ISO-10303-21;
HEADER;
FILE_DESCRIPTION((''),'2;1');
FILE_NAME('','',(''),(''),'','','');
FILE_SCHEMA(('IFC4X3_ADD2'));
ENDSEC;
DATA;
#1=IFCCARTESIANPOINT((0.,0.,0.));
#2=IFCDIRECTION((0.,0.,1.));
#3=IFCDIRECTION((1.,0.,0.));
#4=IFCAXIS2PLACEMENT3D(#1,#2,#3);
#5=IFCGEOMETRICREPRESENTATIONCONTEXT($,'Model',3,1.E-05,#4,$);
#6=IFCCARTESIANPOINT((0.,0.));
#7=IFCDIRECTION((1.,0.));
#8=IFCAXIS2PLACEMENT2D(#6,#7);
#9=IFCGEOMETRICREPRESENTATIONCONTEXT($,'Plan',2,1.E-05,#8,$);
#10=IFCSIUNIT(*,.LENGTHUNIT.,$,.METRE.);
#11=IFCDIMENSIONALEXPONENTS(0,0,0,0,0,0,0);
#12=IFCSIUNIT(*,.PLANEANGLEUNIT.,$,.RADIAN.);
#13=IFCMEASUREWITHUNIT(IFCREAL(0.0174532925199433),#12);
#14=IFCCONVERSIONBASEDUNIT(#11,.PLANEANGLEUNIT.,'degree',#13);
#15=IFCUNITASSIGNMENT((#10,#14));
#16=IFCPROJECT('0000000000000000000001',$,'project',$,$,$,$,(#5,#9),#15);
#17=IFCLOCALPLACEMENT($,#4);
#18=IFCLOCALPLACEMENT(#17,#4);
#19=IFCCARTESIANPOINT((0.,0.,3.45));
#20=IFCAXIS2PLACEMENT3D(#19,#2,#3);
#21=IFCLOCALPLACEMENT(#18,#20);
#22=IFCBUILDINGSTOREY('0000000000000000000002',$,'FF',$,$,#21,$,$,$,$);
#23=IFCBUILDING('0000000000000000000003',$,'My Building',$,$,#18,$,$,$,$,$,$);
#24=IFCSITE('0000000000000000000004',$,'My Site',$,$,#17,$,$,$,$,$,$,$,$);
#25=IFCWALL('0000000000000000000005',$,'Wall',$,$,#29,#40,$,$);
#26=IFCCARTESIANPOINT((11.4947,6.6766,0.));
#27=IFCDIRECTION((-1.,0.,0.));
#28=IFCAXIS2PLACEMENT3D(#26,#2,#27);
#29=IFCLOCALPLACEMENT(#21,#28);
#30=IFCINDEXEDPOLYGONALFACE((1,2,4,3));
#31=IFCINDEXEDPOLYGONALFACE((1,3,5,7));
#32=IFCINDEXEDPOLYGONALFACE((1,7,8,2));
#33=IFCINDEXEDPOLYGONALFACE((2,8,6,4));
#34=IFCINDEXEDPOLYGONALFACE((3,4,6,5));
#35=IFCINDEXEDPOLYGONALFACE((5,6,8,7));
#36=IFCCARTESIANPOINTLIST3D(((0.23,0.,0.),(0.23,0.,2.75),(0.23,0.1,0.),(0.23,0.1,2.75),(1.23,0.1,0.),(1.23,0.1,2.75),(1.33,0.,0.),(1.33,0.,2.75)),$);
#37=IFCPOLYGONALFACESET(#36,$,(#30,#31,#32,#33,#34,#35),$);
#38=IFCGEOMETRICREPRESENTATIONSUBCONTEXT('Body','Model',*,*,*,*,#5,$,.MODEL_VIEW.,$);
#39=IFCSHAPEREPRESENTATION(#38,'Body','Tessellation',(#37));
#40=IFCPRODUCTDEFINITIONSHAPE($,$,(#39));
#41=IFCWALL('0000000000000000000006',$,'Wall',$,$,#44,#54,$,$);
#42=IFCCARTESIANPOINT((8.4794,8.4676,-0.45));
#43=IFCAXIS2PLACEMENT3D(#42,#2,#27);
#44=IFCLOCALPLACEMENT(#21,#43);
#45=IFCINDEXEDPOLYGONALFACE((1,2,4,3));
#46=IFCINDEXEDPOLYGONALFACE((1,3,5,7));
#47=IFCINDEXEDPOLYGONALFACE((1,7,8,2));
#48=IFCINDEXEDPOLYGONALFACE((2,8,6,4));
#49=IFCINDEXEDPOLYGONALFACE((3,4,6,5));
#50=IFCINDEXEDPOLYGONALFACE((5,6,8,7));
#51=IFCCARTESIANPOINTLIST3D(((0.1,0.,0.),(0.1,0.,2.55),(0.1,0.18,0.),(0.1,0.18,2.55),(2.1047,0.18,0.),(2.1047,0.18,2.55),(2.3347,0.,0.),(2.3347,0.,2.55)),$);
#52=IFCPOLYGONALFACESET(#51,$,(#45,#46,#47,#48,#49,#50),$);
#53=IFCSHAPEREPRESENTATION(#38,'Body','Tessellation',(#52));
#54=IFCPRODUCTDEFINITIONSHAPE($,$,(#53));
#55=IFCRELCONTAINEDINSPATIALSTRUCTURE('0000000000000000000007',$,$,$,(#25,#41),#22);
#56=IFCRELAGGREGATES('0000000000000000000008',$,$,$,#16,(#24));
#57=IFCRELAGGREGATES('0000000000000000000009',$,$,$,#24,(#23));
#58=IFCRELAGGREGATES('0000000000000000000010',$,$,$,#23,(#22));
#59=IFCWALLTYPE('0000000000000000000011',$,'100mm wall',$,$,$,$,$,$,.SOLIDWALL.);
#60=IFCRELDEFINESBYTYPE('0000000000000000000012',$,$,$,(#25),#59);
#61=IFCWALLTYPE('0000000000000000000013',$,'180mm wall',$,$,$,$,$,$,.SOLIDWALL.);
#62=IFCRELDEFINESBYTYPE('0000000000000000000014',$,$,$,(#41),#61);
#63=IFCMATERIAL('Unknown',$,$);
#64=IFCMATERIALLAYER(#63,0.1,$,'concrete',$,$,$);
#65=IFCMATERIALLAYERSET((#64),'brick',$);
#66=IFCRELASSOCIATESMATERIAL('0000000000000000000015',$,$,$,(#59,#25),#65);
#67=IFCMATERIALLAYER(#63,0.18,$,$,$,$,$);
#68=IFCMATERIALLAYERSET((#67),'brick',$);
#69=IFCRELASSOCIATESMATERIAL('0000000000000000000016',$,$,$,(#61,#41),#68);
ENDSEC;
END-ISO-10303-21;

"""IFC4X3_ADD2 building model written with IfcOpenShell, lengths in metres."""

from ifc_helpers import new_model, entity, si_unit, converted_unit, frame, origin_with_axes, origin_2d_with_axis, place, context, subcontext, project, spatial, line, indexed_curve, outline, extrude, material, layer, layer_set, layer_usage, type_object, element, save


model = new_model("IFC4X3_ADD2")

# Units and contexts
model_context = context("Model", 3, precision=1e-05, world=origin_with_axes())
plan_context = context("Plan", 2, precision=1e-05, world=origin_2d_with_axis())
body_context_1 = subcontext(model_context, "Body", "Model", "MODEL_VIEW")
ifc_project = project(units=[si_unit("LENGTHUNIT", "METRE"), converted_unit("PLANEANGLEUNIT", "degree", entity("IfcReal", 0.0174532925199433), si_unit("PLANEANGLEUNIT", "RADIAN"), dimensions=[0, 0, 0, 0, 0, 0, 0])], contexts=[model_context, plan_context])

# Site, building, storey
site_placement = place(None, origin_with_axes())
site = spatial("IfcSite", under=ifc_project, at=site_placement, Name="My Site")
building_placement = place(site_placement, origin_with_axes())
building = spatial("IfcBuilding", under=site, at=building_placement, Name="My Building")
storey_placement = place(building_placement, frame((0.0, 0.0, 3.45), z_axis=(0.0, 0.0, 1.0), x_axis=(1.0, 0.0, 0.0)))
storey = spatial("IfcBuildingStorey", under=building, at=storey_placement, Name="FF")

# Shared definitions
ifc_material = material(Name="Unknown")

# Shared definitions
ifc_layer_1 = layer(ifc_material, 0.1, Name="concrete")
ifc_layer_set_1 = layer_set([ifc_layer_1], Name="brick")
wall_type_1 = type_object("IfcWallType", Name="100mm wall", PredefinedType="SOLIDWALL", material=ifc_layer_set_1)

# Walls
ifc_layer_usage_1 = layer_usage(ifc_layer_set_1, "AXIS2", "POSITIVE", 0.0)
wall_1_placement = place(storey_placement, frame((11.4947, 6.6766, 0.0), z_axis=(0.0, 0.0, 1.0), x_axis=(-1.0, 0.0, 0.0)))
element("IfcWall", 1, at=wall_1_placement, inside=storey, type_object=wall_type_1, material=ifc_layer_usage_1, Name="Wall", context=body_context_1, shape_type="SweptSolid", body=[
    extrude(outline(indexed_curve([(0.23, 0.0), (0.23, 0.1), (1.23, 0.1), (1.33, 0.0)], segments=[line(1, 2, 3, 4, 1)])), origin_with_axes(), (0.0, 0.0, 1.0), 2.75),
])
ifc_layer_2 = layer(ifc_material, 0.18)
ifc_layer_set_2 = layer_set([ifc_layer_2], Name="brick")
ifc_layer_usage_2 = layer_usage(ifc_layer_set_2, "AXIS2", "POSITIVE", 0.0)
wall_type_2 = type_object("IfcWallType", Name="180mm wall", PredefinedType="SOLIDWALL", material=ifc_layer_set_2)
wall_2_placement = place(storey_placement, frame((8.4794, 8.4676, -0.45), z_axis=(0.0, 0.0, 1.0), x_axis=(-1.0, 0.0, 0.0)))
element("IfcWall", 2, at=wall_2_placement, inside=storey, type_object=wall_type_2, material=ifc_layer_usage_2, Name="Wall", context=body_context_1, shape_type="SweptSolid", body=[
    extrude(outline(indexed_curve([(0.1, 0.0), (0.1, 0.18), (2.1047, 0.18), (2.3347, 0.0)], segments=[line(1, 2, 3, 4, 1)])), origin_with_axes(), (0.0, 0.0, 1.0), 2.55),
])

save(model, "model.ifc")
